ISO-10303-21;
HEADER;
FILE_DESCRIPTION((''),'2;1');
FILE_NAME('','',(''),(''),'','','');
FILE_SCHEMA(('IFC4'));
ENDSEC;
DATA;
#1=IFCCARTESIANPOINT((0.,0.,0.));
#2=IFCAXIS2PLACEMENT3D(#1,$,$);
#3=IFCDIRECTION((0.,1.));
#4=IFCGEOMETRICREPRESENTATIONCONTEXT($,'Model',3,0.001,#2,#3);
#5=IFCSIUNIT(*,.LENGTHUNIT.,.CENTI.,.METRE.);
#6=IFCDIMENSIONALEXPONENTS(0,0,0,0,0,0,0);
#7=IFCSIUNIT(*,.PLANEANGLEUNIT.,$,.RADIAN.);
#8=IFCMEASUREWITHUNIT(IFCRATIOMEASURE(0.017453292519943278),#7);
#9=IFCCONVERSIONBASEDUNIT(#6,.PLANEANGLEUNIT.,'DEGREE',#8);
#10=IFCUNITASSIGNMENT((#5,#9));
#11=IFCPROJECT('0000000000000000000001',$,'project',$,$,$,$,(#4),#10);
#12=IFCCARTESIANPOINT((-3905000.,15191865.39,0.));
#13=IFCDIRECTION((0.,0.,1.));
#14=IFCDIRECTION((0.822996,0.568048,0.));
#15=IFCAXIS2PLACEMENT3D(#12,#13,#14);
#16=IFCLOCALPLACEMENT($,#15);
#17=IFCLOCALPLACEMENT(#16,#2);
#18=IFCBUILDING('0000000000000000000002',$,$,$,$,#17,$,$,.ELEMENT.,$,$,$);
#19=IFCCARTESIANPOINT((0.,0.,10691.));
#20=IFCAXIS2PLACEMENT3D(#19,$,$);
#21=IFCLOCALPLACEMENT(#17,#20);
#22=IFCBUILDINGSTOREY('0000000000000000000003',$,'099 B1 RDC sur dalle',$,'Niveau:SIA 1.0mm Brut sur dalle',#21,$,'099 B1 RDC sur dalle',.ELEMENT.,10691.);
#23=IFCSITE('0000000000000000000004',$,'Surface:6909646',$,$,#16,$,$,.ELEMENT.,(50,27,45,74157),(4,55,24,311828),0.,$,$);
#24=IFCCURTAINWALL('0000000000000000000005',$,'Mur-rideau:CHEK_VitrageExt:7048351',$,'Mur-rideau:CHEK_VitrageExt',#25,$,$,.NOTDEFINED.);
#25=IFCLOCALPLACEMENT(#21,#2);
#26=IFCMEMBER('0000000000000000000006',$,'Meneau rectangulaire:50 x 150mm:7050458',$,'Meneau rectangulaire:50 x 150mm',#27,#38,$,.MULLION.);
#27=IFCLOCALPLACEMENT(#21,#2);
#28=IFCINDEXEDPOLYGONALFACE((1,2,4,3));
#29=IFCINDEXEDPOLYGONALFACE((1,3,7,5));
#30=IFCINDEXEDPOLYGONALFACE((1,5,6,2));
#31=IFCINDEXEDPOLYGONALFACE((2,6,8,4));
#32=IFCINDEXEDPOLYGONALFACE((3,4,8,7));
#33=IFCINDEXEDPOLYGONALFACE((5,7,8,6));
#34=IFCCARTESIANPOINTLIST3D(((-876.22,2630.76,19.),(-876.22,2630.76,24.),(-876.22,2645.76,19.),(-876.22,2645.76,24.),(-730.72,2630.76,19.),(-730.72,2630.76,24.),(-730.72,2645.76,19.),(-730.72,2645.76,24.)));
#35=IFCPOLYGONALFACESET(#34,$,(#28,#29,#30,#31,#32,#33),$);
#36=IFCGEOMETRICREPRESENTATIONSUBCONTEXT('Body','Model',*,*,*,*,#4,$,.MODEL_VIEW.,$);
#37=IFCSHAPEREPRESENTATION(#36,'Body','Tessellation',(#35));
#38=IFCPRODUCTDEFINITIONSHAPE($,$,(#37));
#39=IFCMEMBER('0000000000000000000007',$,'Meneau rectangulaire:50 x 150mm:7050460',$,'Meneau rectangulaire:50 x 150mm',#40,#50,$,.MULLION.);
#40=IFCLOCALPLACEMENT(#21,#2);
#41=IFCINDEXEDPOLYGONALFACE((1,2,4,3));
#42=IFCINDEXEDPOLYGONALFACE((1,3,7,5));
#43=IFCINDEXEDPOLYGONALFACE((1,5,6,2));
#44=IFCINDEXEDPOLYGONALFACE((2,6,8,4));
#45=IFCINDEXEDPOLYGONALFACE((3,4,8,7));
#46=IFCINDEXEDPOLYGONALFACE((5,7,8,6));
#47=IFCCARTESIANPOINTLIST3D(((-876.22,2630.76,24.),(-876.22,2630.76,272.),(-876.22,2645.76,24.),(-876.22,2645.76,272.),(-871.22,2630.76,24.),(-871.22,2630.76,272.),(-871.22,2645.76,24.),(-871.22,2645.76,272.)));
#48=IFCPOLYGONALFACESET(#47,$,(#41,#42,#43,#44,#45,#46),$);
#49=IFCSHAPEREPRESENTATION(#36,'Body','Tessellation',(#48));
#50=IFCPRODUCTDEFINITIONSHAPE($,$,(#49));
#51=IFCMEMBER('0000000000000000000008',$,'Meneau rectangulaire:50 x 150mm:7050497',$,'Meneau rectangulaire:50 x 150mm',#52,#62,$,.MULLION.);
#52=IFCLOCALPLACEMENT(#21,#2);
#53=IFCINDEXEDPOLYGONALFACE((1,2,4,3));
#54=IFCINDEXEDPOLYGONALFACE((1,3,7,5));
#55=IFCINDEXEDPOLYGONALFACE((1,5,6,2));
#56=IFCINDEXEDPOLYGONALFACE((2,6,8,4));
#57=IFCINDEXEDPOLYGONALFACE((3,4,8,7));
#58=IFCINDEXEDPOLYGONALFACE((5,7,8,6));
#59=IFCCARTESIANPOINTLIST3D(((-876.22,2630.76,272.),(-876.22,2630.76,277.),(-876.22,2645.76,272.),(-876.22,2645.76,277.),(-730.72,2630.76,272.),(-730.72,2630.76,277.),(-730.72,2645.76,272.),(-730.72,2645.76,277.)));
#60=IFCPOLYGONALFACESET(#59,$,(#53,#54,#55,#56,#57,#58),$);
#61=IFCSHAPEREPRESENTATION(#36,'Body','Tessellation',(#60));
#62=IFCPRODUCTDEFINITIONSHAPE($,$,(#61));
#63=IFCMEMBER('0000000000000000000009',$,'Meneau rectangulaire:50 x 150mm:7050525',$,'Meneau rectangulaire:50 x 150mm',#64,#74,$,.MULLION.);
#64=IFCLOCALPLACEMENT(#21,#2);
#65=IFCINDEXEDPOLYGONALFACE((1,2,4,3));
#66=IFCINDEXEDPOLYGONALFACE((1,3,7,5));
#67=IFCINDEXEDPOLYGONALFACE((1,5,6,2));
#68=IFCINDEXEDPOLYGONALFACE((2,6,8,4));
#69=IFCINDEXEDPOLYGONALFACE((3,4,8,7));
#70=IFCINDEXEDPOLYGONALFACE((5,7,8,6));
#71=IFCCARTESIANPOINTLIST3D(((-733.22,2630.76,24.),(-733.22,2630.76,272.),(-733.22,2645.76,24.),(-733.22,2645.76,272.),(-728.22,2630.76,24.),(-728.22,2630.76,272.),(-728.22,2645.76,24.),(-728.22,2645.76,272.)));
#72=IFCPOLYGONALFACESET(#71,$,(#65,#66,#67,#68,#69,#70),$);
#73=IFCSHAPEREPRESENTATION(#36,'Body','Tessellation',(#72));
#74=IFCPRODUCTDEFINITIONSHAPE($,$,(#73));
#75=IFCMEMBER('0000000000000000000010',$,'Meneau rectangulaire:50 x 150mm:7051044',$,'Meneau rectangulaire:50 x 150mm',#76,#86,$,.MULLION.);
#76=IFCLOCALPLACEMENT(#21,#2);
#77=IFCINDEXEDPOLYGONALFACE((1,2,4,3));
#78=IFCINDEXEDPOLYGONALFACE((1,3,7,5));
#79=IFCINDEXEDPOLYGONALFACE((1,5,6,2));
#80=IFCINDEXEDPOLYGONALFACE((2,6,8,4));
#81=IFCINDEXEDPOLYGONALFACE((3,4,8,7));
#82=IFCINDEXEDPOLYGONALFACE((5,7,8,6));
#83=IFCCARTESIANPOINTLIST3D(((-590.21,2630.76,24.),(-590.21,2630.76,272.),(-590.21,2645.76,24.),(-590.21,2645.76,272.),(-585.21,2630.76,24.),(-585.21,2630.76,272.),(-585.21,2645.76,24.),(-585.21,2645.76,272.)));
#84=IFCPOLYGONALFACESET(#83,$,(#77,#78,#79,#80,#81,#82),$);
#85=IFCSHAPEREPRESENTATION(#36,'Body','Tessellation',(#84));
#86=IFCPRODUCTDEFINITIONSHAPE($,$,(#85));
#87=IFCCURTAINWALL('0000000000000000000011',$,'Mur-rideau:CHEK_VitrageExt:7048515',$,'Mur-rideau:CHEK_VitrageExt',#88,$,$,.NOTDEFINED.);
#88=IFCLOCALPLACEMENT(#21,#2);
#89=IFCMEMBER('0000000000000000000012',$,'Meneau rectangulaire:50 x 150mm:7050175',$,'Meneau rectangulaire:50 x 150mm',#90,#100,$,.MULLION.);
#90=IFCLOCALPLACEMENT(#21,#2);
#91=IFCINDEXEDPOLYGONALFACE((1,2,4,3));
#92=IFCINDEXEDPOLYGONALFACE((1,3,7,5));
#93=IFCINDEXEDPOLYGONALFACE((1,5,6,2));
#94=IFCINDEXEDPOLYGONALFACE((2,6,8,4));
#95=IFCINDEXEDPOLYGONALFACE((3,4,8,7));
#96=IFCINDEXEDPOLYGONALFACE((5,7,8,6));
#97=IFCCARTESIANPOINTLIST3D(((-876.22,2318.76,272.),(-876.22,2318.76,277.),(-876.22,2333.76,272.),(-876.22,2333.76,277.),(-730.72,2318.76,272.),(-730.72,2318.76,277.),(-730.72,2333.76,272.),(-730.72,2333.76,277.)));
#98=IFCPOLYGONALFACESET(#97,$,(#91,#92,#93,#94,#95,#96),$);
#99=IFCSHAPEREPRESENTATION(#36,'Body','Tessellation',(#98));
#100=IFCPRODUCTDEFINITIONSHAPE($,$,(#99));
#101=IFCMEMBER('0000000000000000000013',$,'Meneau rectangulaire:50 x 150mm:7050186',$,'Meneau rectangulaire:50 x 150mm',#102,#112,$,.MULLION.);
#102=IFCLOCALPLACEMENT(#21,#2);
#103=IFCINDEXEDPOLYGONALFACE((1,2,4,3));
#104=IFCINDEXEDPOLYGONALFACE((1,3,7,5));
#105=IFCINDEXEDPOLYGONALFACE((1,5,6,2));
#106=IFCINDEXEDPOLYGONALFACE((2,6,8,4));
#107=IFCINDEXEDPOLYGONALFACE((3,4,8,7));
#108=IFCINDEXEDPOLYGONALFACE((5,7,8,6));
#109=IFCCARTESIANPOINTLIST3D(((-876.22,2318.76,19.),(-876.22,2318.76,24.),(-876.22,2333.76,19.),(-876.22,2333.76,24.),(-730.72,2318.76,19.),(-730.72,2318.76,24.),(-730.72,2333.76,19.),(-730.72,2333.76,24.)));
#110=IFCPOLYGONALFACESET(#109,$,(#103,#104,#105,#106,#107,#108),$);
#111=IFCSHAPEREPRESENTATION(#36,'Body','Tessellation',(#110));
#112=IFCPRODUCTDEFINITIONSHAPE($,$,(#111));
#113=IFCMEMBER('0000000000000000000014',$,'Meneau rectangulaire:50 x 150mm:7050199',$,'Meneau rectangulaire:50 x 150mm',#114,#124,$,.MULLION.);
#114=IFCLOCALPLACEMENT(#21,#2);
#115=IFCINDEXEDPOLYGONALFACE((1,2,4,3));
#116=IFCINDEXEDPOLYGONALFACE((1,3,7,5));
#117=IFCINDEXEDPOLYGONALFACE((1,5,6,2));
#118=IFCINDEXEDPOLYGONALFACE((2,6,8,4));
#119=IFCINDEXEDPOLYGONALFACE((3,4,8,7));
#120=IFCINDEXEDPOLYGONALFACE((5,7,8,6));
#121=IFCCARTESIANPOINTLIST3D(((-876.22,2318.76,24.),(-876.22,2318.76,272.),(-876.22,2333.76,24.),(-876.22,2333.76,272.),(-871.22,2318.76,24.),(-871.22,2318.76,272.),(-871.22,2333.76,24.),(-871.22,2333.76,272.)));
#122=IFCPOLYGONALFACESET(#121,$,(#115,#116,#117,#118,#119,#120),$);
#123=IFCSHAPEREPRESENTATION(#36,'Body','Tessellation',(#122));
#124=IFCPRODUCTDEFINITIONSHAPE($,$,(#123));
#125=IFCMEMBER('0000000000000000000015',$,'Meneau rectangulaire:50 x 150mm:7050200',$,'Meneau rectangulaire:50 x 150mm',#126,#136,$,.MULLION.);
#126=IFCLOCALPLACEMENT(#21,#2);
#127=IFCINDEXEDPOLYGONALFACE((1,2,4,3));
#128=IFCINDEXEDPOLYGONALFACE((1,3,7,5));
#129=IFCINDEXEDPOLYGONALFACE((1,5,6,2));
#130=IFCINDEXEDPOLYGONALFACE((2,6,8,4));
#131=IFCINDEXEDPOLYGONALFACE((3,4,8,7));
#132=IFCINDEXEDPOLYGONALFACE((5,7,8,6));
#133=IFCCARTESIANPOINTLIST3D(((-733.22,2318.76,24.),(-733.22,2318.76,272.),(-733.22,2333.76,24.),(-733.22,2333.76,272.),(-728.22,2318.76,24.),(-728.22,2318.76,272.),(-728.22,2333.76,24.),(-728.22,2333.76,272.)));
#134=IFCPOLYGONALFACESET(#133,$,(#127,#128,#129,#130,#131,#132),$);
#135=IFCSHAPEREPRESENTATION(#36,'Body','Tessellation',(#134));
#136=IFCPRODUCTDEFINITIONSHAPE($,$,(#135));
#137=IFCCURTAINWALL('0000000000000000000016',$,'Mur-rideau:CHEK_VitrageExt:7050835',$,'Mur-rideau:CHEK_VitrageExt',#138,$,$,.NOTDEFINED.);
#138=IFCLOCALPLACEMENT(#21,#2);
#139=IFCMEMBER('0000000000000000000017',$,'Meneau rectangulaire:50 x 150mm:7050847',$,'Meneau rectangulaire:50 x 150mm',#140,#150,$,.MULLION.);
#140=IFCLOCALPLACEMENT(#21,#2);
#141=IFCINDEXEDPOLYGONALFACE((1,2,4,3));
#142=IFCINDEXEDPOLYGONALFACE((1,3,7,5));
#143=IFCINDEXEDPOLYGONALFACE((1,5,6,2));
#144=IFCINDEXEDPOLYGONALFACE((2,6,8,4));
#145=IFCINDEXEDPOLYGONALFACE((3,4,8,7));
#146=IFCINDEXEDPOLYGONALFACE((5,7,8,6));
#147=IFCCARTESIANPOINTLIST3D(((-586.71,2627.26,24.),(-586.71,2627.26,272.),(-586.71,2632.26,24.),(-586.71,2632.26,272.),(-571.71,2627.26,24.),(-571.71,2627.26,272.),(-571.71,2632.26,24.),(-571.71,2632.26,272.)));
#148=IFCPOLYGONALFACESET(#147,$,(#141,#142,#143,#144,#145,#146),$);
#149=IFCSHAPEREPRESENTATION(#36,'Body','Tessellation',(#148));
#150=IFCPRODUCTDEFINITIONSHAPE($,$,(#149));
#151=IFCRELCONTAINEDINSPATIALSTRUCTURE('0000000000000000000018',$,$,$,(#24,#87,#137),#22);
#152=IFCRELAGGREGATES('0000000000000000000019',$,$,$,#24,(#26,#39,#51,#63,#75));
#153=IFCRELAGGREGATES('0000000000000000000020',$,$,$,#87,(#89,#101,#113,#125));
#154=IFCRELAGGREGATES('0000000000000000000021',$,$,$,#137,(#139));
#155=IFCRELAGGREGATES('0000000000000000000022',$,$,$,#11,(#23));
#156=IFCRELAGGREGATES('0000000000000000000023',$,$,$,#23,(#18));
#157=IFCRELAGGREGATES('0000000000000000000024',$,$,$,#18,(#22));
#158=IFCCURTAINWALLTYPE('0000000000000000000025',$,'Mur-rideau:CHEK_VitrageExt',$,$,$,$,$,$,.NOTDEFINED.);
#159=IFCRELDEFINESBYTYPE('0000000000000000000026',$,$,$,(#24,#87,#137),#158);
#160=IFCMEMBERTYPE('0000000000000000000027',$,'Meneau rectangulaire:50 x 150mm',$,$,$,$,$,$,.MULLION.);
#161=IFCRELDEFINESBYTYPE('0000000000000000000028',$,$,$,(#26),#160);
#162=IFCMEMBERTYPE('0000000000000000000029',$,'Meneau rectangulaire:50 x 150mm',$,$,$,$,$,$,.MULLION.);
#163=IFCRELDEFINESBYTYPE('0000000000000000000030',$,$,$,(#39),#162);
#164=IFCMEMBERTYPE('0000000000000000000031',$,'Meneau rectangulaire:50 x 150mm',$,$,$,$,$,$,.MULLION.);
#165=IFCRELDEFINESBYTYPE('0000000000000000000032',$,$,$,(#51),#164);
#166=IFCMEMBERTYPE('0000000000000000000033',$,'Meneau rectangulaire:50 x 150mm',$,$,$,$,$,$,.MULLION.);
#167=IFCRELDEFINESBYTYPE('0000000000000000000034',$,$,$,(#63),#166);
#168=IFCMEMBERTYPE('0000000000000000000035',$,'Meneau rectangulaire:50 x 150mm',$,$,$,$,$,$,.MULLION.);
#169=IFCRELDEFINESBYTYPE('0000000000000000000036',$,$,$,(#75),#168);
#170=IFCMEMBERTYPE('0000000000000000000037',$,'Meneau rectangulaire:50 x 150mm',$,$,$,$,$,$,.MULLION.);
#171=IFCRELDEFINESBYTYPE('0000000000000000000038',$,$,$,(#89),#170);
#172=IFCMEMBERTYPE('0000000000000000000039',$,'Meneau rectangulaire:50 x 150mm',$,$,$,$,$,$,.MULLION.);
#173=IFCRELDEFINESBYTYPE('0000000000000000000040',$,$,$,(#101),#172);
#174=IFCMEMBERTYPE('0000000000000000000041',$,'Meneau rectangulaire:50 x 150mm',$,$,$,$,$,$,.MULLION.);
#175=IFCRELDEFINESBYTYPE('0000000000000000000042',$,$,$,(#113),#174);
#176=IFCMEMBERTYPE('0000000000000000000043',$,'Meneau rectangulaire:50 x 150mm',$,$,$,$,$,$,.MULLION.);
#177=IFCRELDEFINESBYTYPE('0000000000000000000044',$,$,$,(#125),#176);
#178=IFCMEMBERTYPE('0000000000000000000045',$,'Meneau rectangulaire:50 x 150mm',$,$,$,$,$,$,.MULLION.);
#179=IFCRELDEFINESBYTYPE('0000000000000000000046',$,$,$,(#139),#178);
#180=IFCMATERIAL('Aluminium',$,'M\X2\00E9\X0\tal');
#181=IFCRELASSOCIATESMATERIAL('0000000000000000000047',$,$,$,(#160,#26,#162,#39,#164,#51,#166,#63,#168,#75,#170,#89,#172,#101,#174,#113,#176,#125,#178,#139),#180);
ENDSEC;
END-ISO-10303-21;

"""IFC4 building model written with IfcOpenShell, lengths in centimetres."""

from ifc_helpers import new_model, entity, si_unit, converted_unit, direction, frame, origin, place, context, subcontext, project, spatial, indexed_curve, outline, extrude, source, transform, mapped, material, type_object, type_shapes, element, aggregate, save


model = new_model("IFC4")

# Units and contexts
model_context = context("Model", 3, precision=0.001, world=origin(), true_north=direction((0.0, 1.0)))
body_context = subcontext(model_context, "Body", "Model", "MODEL_VIEW")
ifc_project = project(units=[si_unit("LENGTHUNIT", "METRE", prefix="CENTI"), converted_unit("PLANEANGLEUNIT", "DEGREE", entity("IfcRatioMeasure", 0.017453292519943278), si_unit("PLANEANGLEUNIT", "RADIAN"), dimensions=[0, 0, 0, 0, 0, 0, 0])], contexts=[model_context])

# Site, building, storey
site_placement = place(None, frame((-3905000.0, 15191865.39, 0.0), z_axis=(0.0, 0.0, 1.0), x_axis=(0.822996, 0.568048, 0.0)))
site = spatial("IfcSite", under=ifc_project, at=site_placement, Name="Surface:6909646", CompositionType="ELEMENT", RefLatitude=(50, 27, 45, 74157), RefLongitude=(4, 55, 24, 311828), RefElevation=0.0)
building_placement = place(site_placement, origin())
building = spatial("IfcBuilding", under=site, at=building_placement, CompositionType="ELEMENT")
storey_placement = place(building_placement, frame((0.0, 0.0, 10691.0)))
storey = spatial("IfcBuildingStorey", under=building, at=storey_placement, Name="099 B1 RDC sur dalle", ObjectType="Niveau:SIA 1.0mm Brut sur dalle", LongName="099 B1 RDC sur dalle", CompositionType="ELEMENT", Elevation=10691.0)

# Curtain walls, members
curtain_wall_type = type_object("IfcCurtainWallType", Name="Mur-rideau:CHEK_VitrageExt", PredefinedType="NOTDEFINED")
curtain_wall_1_placement = place(storey_placement, frame((0.0, 0.0, -10691.0)))
curtain_wall_1 = element("IfcCurtainWall", 1, at=curtain_wall_1_placement, inside=storey, type_object=curtain_wall_type, Name="Mur-rideau:CHEK_VitrageExt:7048351", ObjectType="Mur-rideau:CHEK_VitrageExt", PredefinedType="NOTDEFINED")
ifc_material_1 = material(Name="Aluminium", Category="Métal")
member_type_1 = type_object("IfcMemberType", Name="Meneau rectangulaire:50 x 150mm", PredefinedType="MULLION", material=ifc_material_1)
shared_shape_1 = source(origin(), body_context, "Body", "SweptSolid", [
    extrude(outline(indexed_curve([(-7.5, -2.5), (7.5, -2.5), (7.5, 2.5), (-7.5, 2.5), (-7.5, -2.5)], self_intersect=False)), frame((-2.5, -6.0, -145.51), z_axis=(0.0, 0.0, 1.0), x_axis=(0.0, -1.0, 0.0)), (0.0, 0.0, 1.0), 145.51),
])
type_shapes(member_type_1, [shared_shape_1])
member_1_placement = place(curtain_wall_1_placement, frame((-876.22, 2632.26, 10710.0), z_axis=(-1.0, 0.0, 0.0), x_axis=(0.0, 0.0, -1.0)))
member_1 = element("IfcMember", 2, at=member_1_placement, type_object=member_type_1, material=ifc_material_1, Name="Meneau rectangulaire:50 x 150mm:7050458", ObjectType="Meneau rectangulaire:50 x 150mm", PredefinedType="MULLION", context=body_context, shape_type="MappedRepresentation", body=[
    mapped(shared_shape_1, transform((0.0, 0.0, 0.0), scale=1.0)),
])
member_type_2 = type_object("IfcMemberType", Name="Meneau rectangulaire:50 x 150mm", PredefinedType="MULLION", material=ifc_material_1)
shared_shape_2 = source(origin(), body_context, "Body", "SweptSolid", [
    extrude(outline(indexed_curve([(-7.5, -2.5), (7.5, -2.5), (7.5, 2.5), (-7.5, 2.5), (-7.5, -2.5)], self_intersect=False)), frame((-2.5, -6.0, -248.0), z_axis=(0.0, 0.0, 1.0), x_axis=(0.0, -1.0, 0.0)), (0.0, 0.0, 1.0), 248.0),
])
type_shapes(member_type_2, [shared_shape_2])
member_2_placement = place(curtain_wall_1_placement, frame((-876.22, 2632.26, 10963.0), z_axis=(0.0, 0.0, 1.0), x_axis=(-1.0, 0.0, 0.0)))
member_2 = element("IfcMember", 3, at=member_2_placement, type_object=member_type_2, material=ifc_material_1, Name="Meneau rectangulaire:50 x 150mm:7050460", ObjectType="Meneau rectangulaire:50 x 150mm", PredefinedType="MULLION", context=body_context, shape_type="MappedRepresentation", body=[
    mapped(shared_shape_2, transform((0.0, 0.0, 0.0), scale=1.0)),
])
member_type_3 = type_object("IfcMemberType", Name="Meneau rectangulaire:50 x 150mm", PredefinedType="MULLION", material=ifc_material_1)
shared_shape_3 = source(origin(), body_context, "Body", "SweptSolid", [
    extrude(outline(indexed_curve([(-7.5, -2.5), (7.5, -2.5), (7.5, 2.5), (-7.5, 2.5), (-7.5, -2.5)], self_intersect=False)), frame((-2.5, -6.0, -145.51), z_axis=(0.0, 0.0, 1.0), x_axis=(0.0, -1.0, 0.0)), (0.0, 0.0, 1.0), 145.51),
])
type_shapes(member_type_3, [shared_shape_3])
member_3_placement = place(curtain_wall_1_placement, frame((-730.72, 2632.26, 10968.0), z_axis=(1.0, 0.0, 0.0), x_axis=(0.0, 0.0, 1.0)))
member_3 = element("IfcMember", 4, at=member_3_placement, type_object=member_type_3, material=ifc_material_1, Name="Meneau rectangulaire:50 x 150mm:7050497", ObjectType="Meneau rectangulaire:50 x 150mm", PredefinedType="MULLION", context=body_context, shape_type="MappedRepresentation", body=[
    mapped(shared_shape_3, transform((0.0, 0.0, 0.0), scale=1.0)),
])
member_type_4 = type_object("IfcMemberType", Name="Meneau rectangulaire:50 x 150mm", PredefinedType="MULLION", material=ifc_material_1)
shared_shape_4 = source(origin(), body_context, "Body", "SweptSolid", [
    extrude(outline(indexed_curve([(-7.5, -2.5), (7.5, -2.5), (7.5, 2.5), (-7.5, 2.5), (-7.5, -2.5)], self_intersect=False)), frame((0.0, -6.0, -248.0), z_axis=(0.0, 0.0, 1.0), x_axis=(0.0, -1.0, 0.0)), (0.0, 0.0, 1.0), 248.0),
])
type_shapes(member_type_4, [shared_shape_4])
member_4_placement = place(curtain_wall_1_placement, frame((-730.72, 2632.26, 10715.0), z_axis=(0.0, 0.0, -1.0), x_axis=(1.0, 0.0, 0.0)))
member_4 = element("IfcMember", 5, at=member_4_placement, type_object=member_type_4, material=ifc_material_1, Name="Meneau rectangulaire:50 x 150mm:7050525", ObjectType="Meneau rectangulaire:50 x 150mm", PredefinedType="MULLION", context=body_context, shape_type="MappedRepresentation", body=[
    mapped(shared_shape_4, transform((0.0, 0.0, 0.0), scale=1.0)),
])
member_type_5 = type_object("IfcMemberType", Name="Meneau rectangulaire:50 x 150mm", PredefinedType="MULLION", material=ifc_material_1)
shared_shape_5 = source(origin(), body_context, "Body", "SweptSolid", [
    extrude(outline(indexed_curve([(-7.5, -2.5), (7.5, -2.5), (7.5, 2.5), (-7.5, 2.5), (-7.5, -2.5)], self_intersect=False)), frame((-2.5, -6.0, -248.0), z_axis=(0.0, 0.0, 1.0), x_axis=(0.0, -1.0, 0.0)), (0.0, 0.0, 1.0), 248.0),
])
type_shapes(member_type_5, [shared_shape_5])
member_5_placement = place(curtain_wall_1_placement, frame((-585.21, 2632.26, 10715.0), z_axis=(0.0, 0.0, -1.0), x_axis=(1.0, 0.0, 0.0)))
member_5 = element("IfcMember", 6, at=member_5_placement, type_object=member_type_5, material=ifc_material_1, Name="Meneau rectangulaire:50 x 150mm:7051044", ObjectType="Meneau rectangulaire:50 x 150mm", PredefinedType="MULLION", context=body_context, shape_type="MappedRepresentation", body=[
    mapped(shared_shape_5, transform((0.0, 0.0, 0.0), scale=1.0)),
])
curtain_wall_2_placement = place(storey_placement, frame((0.0, 0.0, -10691.0)))
curtain_wall_2 = element("IfcCurtainWall", 7, at=curtain_wall_2_placement, inside=storey, type_object=curtain_wall_type, Name="Mur-rideau:CHEK_VitrageExt:7048515", ObjectType="Mur-rideau:CHEK_VitrageExt", PredefinedType="NOTDEFINED")
member_type_6 = type_object("IfcMemberType", Name="Meneau rectangulaire:50 x 150mm", PredefinedType="MULLION", material=ifc_material_1)
shared_shape_6 = source(origin(), body_context, "Body", "SweptSolid", [
    extrude(outline(indexed_curve([(-7.5, -2.5), (7.5, -2.5), (7.5, 2.5), (-7.5, 2.5), (-7.5, -2.5)], self_intersect=False)), frame((-2.5, 6.0, -145.51), z_axis=(0.0, 0.0, 1.0), x_axis=(0.0, -1.0, 0.0)), (0.0, 0.0, 1.0), 145.51),
])
type_shapes(member_type_6, [shared_shape_6])
member_6_placement = place(curtain_wall_2_placement, frame((-730.72, 2332.26, 10968.0), z_axis=(1.0, 0.0, 0.0), x_axis=(0.0, 0.0, 1.0)))
member_6 = element("IfcMember", 8, at=member_6_placement, type_object=member_type_6, material=ifc_material_1, Name="Meneau rectangulaire:50 x 150mm:7050175", ObjectType="Meneau rectangulaire:50 x 150mm", PredefinedType="MULLION", context=body_context, shape_type="MappedRepresentation", body=[
    mapped(shared_shape_6, transform((0.0, 0.0, 0.0), scale=1.0)),
])
member_type_7 = type_object("IfcMemberType", Name="Meneau rectangulaire:50 x 150mm", PredefinedType="MULLION", material=ifc_material_1)
shared_shape_7 = source(origin(), body_context, "Body", "SweptSolid", [
    extrude(outline(indexed_curve([(-7.5, -2.5), (7.5, -2.5), (7.5, 2.5), (-7.5, 2.5), (-7.5, -2.5)], self_intersect=False)), frame((-2.5, 6.0, -145.51), z_axis=(0.0, 0.0, 1.0), x_axis=(0.0, -1.0, 0.0)), (0.0, 0.0, 1.0), 145.51),
])
type_shapes(member_type_7, [shared_shape_7])
member_7_placement = place(curtain_wall_2_placement, frame((-876.22, 2332.26, 10710.0), z_axis=(-1.0, 0.0, 0.0), x_axis=(0.0, 0.0, -1.0)))
member_7 = element("IfcMember", 9, at=member_7_placement, type_object=member_type_7, material=ifc_material_1, Name="Meneau rectangulaire:50 x 150mm:7050186", ObjectType="Meneau rectangulaire:50 x 150mm", PredefinedType="MULLION", context=body_context, shape_type="MappedRepresentation", body=[
    mapped(shared_shape_7, transform((0.0, 0.0, 0.0), scale=1.0)),
])
member_type_8 = type_object("IfcMemberType", Name="Meneau rectangulaire:50 x 150mm", PredefinedType="MULLION", material=ifc_material_1)
shared_shape_8 = source(origin(), body_context, "Body", "SweptSolid", [
    extrude(outline(indexed_curve([(-7.5, -2.5), (7.5, -2.5), (7.5, 2.5), (-7.5, 2.5), (-7.5, -2.5)], self_intersect=False)), frame((-2.5, 6.0, -248.0), z_axis=(0.0, 0.0, 1.0), x_axis=(0.0, -1.0, 0.0)), (0.0, 0.0, 1.0), 248.0),
])
type_shapes(member_type_8, [shared_shape_8])
member_8_placement = place(curtain_wall_2_placement, frame((-876.22, 2332.26, 10963.0), z_axis=(0.0, 0.0, 1.0), x_axis=(-1.0, 0.0, 0.0)))
member_8 = element("IfcMember", 10, at=member_8_placement, type_object=member_type_8, material=ifc_material_1, Name="Meneau rectangulaire:50 x 150mm:7050199", ObjectType="Meneau rectangulaire:50 x 150mm", PredefinedType="MULLION", context=body_context, shape_type="MappedRepresentation", body=[
    mapped(shared_shape_8, transform((0.0, 0.0, 0.0), scale=1.0)),
])
member_type_9 = type_object("IfcMemberType", Name="Meneau rectangulaire:50 x 150mm", PredefinedType="MULLION", material=ifc_material_1)
shared_shape_9 = source(origin(), body_context, "Body", "SweptSolid", [
    extrude(outline(indexed_curve([(-7.5, -2.5), (7.5, -2.5), (7.5, 2.5), (-7.5, 2.5), (-7.5, -2.5)], self_intersect=False)), frame((0.0, 6.0, -248.0), z_axis=(0.0, 0.0, 1.0), x_axis=(0.0, -1.0, 0.0)), (0.0, 0.0, 1.0), 248.0),
])
type_shapes(member_type_9, [shared_shape_9])
member_9_placement = place(curtain_wall_2_placement, frame((-730.72, 2332.26, 10715.0), z_axis=(0.0, 0.0, -1.0), x_axis=(1.0, 0.0, 0.0)))
member_9 = element("IfcMember", 11, at=member_9_placement, type_object=member_type_9, material=ifc_material_1, Name="Meneau rectangulaire:50 x 150mm:7050200", ObjectType="Meneau rectangulaire:50 x 150mm", PredefinedType="MULLION", context=body_context, shape_type="MappedRepresentation", body=[
    mapped(shared_shape_9, transform((0.0, 0.0, 0.0), scale=1.0)),
])

# Curtain wall, member
curtain_wall_3_placement = place(storey_placement, frame((0.0, 0.0, -10691.0)))
curtain_wall_3 = element("IfcCurtainWall", 12, at=curtain_wall_3_placement, inside=storey, type_object=curtain_wall_type, Name="Mur-rideau:CHEK_VitrageExt:7050835", ObjectType="Mur-rideau:CHEK_VitrageExt", PredefinedType="NOTDEFINED")
member_type_10 = type_object("IfcMemberType", Name="Meneau rectangulaire:50 x 150mm", PredefinedType="MULLION", material=ifc_material_1)
shared_shape_10 = source(origin(), body_context, "Body", "SweptSolid", [
    extrude(outline(indexed_curve([(-7.5, -2.5), (7.5, -2.5), (7.5, 2.5), (-7.5, 2.5), (-7.5, -2.5)], self_intersect=False)), frame((-2.5, 6.0, -248.0), z_axis=(0.0, 0.0, 1.0), x_axis=(0.0, -1.0, 0.0)), (0.0, 0.0, 1.0), 248.0),
])
type_shapes(member_type_10, [shared_shape_10])
member_10_placement = place(curtain_wall_3_placement, frame((-585.21, 2632.26, 10715.0), z_axis=(0.0, 0.0, -1.0), x_axis=(0.0, 1.0, 0.0)))
member_10 = element("IfcMember", 13, at=member_10_placement, type_object=member_type_10, material=ifc_material_1, Name="Meneau rectangulaire:50 x 150mm:7050847", ObjectType="Meneau rectangulaire:50 x 150mm", PredefinedType="MULLION", context=body_context, shape_type="MappedRepresentation", body=[
    mapped(shared_shape_10, transform((0.0, 0.0, 0.0), scale=1.0)),
])

aggregate(curtain_wall_1, [member_1, member_2, member_3, member_4, member_5])
aggregate(curtain_wall_2, [member_6, member_7, member_8, member_9])
aggregate(curtain_wall_3, [member_10])

save(model, "model.ifc")
